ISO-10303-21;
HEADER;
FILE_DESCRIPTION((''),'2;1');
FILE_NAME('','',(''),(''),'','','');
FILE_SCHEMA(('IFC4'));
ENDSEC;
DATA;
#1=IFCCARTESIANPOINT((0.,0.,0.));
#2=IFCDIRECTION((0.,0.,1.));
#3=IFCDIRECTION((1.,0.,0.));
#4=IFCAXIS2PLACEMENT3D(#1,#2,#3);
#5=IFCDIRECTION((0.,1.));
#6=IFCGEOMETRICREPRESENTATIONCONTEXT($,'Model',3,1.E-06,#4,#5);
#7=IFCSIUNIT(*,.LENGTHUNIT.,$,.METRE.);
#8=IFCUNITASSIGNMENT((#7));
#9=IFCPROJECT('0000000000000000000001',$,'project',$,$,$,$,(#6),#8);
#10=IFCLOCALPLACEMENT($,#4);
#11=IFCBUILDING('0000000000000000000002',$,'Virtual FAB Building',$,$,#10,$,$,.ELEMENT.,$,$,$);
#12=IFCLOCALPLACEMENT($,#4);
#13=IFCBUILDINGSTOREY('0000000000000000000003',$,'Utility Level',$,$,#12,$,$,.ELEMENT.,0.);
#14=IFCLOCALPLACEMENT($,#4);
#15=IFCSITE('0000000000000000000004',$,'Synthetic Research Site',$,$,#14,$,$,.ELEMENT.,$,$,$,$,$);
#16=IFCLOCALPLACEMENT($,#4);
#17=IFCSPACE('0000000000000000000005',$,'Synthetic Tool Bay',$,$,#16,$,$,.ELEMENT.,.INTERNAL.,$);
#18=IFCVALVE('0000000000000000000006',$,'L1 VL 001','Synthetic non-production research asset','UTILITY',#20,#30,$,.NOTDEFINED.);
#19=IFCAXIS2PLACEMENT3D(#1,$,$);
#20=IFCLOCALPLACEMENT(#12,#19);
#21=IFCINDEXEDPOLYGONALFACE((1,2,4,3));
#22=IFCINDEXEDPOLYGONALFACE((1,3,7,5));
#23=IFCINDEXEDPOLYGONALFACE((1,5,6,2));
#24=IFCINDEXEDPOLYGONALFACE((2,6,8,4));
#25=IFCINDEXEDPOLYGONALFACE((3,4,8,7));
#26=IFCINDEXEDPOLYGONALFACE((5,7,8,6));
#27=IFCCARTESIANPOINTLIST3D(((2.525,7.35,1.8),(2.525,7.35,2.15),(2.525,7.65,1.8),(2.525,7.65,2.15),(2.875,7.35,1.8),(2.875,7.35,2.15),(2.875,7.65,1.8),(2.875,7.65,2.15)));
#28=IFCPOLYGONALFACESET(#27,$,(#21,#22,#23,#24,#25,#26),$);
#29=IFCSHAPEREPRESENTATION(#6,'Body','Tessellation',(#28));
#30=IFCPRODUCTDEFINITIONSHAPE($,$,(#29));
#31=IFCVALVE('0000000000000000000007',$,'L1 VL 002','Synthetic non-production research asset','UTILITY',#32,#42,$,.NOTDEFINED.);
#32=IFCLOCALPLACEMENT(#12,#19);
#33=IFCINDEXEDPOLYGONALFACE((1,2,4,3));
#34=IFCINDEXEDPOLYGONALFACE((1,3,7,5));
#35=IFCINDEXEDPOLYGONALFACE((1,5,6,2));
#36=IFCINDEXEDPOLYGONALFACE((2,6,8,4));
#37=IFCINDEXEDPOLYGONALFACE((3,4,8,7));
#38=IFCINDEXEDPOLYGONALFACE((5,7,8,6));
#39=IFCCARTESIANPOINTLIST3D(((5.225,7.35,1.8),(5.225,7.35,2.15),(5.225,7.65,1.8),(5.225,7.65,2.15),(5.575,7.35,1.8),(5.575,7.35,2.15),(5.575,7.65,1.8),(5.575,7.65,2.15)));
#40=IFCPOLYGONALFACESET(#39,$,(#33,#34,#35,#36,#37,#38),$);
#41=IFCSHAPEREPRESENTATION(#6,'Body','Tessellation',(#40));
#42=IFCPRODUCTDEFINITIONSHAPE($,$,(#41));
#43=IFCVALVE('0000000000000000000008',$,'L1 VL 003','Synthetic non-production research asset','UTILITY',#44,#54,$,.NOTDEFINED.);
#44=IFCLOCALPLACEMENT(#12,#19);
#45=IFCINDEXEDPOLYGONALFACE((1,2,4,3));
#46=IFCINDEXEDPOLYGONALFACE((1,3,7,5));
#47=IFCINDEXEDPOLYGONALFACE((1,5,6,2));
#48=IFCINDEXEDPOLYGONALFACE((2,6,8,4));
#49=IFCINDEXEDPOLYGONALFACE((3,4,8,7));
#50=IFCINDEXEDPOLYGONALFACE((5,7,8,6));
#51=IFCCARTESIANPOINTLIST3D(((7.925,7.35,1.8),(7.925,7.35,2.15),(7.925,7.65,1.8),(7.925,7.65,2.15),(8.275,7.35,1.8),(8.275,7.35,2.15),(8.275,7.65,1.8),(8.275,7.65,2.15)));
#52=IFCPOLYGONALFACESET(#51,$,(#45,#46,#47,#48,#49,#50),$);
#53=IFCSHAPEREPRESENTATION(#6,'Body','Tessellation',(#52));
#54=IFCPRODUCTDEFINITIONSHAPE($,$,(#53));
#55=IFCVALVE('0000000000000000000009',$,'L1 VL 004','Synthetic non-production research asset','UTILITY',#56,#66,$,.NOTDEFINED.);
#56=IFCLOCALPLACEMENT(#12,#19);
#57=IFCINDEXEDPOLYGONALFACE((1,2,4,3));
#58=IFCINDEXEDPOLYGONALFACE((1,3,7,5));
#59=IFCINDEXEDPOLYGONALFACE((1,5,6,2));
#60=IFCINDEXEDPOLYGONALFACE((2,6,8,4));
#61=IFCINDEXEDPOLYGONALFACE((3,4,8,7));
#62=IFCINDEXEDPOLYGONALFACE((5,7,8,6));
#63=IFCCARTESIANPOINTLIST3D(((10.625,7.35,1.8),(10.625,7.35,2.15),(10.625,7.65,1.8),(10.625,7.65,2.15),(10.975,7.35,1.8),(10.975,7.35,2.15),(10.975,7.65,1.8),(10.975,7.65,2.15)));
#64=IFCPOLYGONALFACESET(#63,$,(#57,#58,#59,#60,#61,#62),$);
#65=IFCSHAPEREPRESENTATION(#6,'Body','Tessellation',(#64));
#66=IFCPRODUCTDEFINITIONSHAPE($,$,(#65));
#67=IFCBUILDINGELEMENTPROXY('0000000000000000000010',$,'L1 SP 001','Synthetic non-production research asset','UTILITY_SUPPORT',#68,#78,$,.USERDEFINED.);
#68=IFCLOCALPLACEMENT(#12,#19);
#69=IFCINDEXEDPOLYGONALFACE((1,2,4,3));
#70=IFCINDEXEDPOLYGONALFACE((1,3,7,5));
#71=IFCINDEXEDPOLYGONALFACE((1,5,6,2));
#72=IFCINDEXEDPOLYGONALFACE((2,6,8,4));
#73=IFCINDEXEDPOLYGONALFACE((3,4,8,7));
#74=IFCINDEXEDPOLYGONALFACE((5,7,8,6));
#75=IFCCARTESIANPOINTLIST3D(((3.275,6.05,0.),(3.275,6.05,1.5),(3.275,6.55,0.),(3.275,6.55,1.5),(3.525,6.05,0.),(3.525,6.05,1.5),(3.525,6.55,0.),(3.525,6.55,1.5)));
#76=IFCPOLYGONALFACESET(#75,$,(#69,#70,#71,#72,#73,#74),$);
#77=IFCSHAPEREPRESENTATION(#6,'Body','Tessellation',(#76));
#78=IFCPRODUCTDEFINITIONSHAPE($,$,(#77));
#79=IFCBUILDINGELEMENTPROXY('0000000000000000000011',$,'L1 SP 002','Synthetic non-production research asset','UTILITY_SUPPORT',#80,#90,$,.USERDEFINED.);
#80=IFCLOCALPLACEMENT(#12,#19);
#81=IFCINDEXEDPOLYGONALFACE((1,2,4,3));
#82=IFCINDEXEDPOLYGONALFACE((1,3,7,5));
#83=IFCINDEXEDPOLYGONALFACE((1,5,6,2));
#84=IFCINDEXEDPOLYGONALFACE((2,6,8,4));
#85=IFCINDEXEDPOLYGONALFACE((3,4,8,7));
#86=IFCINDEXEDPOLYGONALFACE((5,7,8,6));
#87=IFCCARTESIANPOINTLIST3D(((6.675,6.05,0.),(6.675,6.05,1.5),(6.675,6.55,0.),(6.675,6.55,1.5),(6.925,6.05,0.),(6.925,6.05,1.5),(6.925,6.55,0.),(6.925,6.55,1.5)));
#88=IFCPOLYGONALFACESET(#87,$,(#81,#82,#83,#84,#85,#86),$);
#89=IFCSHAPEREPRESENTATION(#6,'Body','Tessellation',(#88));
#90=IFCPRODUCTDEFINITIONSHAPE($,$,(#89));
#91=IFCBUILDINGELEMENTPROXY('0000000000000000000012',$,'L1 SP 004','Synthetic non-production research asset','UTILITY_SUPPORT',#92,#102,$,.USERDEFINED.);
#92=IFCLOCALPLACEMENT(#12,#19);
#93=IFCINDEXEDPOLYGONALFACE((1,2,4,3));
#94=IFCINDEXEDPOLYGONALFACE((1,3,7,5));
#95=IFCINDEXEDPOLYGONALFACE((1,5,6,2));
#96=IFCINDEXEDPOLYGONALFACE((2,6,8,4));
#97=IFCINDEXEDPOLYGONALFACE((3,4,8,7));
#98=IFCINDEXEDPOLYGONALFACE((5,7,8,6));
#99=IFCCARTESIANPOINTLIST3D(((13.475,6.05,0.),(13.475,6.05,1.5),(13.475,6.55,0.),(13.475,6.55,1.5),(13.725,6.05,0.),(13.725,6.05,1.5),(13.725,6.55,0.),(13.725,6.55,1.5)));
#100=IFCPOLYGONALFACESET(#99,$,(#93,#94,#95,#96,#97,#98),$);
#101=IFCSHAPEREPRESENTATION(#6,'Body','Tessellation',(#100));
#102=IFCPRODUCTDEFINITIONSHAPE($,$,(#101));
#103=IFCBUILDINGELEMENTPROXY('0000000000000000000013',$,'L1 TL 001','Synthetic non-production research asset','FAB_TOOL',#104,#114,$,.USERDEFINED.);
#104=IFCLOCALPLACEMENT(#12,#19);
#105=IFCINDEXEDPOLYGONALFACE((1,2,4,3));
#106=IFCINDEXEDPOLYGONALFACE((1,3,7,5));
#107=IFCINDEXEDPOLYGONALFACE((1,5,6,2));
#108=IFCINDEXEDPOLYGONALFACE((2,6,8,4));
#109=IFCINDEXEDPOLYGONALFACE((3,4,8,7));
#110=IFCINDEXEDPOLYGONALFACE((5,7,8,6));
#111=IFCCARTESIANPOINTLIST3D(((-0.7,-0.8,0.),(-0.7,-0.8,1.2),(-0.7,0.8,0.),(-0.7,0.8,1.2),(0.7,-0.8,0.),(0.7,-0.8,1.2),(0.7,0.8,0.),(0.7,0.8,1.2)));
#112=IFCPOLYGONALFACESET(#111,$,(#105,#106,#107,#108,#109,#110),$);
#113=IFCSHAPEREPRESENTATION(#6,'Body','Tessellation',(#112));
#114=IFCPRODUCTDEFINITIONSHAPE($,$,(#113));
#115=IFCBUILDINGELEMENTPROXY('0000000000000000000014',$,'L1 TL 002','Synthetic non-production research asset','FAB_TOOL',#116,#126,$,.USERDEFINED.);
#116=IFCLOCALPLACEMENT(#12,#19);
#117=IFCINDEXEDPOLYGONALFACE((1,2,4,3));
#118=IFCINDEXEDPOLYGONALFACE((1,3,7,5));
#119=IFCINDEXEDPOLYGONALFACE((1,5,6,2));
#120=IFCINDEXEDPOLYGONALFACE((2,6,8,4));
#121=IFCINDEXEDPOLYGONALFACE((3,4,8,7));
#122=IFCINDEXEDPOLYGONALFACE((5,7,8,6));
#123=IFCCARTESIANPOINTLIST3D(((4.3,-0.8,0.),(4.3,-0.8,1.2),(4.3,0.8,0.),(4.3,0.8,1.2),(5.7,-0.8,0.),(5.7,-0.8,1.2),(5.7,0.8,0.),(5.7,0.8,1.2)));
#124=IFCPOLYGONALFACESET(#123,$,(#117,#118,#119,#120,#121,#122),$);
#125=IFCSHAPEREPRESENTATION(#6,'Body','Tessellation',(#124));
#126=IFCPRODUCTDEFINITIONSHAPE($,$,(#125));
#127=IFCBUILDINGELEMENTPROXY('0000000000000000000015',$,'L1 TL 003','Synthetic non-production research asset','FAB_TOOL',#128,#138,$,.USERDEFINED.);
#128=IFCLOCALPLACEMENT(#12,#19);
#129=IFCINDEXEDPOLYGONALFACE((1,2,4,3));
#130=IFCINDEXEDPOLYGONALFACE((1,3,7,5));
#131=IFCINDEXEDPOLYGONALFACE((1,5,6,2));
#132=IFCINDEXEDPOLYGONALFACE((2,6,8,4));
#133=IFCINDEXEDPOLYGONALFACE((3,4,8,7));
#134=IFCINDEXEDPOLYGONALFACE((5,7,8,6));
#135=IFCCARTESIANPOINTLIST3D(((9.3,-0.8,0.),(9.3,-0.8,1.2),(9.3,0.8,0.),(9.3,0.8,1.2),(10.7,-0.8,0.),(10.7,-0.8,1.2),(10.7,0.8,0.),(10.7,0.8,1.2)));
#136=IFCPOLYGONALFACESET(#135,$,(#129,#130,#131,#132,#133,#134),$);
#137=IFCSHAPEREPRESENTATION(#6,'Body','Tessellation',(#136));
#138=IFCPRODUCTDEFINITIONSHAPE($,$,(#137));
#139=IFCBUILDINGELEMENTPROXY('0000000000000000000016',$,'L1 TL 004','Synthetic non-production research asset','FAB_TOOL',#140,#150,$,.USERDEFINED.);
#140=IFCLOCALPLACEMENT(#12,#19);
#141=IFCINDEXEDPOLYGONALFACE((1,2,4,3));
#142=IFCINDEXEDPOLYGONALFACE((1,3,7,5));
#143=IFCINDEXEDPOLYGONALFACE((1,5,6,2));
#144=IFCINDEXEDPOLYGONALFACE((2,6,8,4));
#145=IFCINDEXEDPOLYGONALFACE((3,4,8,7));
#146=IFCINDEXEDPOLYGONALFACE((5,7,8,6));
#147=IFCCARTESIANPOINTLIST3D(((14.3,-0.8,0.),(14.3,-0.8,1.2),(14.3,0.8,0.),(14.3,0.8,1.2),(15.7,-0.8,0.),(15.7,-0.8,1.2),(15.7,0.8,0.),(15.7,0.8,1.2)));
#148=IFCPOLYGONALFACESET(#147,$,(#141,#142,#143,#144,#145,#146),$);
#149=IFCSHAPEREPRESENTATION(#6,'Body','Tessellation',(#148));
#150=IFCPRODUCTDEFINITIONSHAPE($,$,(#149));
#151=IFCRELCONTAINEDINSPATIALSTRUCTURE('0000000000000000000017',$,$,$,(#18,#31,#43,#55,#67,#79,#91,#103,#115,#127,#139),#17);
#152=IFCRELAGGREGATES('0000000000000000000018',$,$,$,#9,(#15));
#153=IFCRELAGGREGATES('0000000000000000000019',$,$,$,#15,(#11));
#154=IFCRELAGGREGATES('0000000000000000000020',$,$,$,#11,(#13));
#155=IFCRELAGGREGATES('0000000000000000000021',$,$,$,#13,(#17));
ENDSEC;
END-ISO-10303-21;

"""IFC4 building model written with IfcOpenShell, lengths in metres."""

from ifc_helpers import new_model, si_unit, direction, frame, origin_with_axes, origin_2d_with_axis, place, context, project, spatial, rectangle, extrude, element, save


model = new_model("IFC4")

# Units and contexts
model_context = context("Model", 3, precision=1e-06, world=origin_with_axes(), true_north=direction((0.0, 1.0)))
ifc_project = project(units=[si_unit("LENGTHUNIT", "METRE")], contexts=[model_context])

# Site, building, storey, space
site_placement = place(None, origin_with_axes())
site = spatial("IfcSite", under=ifc_project, at=site_placement, Name="Synthetic Research Site", CompositionType="ELEMENT")
building_placement = place(None, origin_with_axes())
building = spatial("IfcBuilding", under=site, at=building_placement, Name="Virtual FAB Building", CompositionType="ELEMENT")
storey_placement = place(None, origin_with_axes())
storey = spatial("IfcBuildingStorey", under=building, at=storey_placement, Name="Utility Level", CompositionType="ELEMENT", Elevation=0.0)
space_placement = place(None, origin_with_axes())
space = spatial("IfcSpace", under=storey, at=space_placement, Name="Synthetic Tool Bay", CompositionType="ELEMENT", PredefinedType="INTERNAL")

# Valves
for number, where, z_axis, x_axis, name in (
    (1, (2.7, 7.5, 1.8), (0.0, 0.0, 1.0), (1.0, 0.0, 0.0), "L1 VL 001"),
    (2, (5.4, 7.5, 1.8), (0.0, 0.0, 1.0), (1.0, 0.0, 0.0), "L1 VL 002"),
    (3, (8.1, 7.5, 1.8), (0.0, 0.0, 1.0), (1.0, 0.0, 0.0), "L1 VL 003"),
    (4, (10.8, 7.5, 1.8), (0.0, 0.0, 1.0), (1.0, 0.0, 0.0), "L1 VL 004"),
):
    element("IfcValve", number, at=place(None, frame(where, z_axis=z_axis, x_axis=x_axis)), inside=space, Name=name, Description="Synthetic non-production research asset", ObjectType="UTILITY", PredefinedType="NOTDEFINED", context=model_context, shape_type="SweptSolid", body=[
        extrude(rectangle(XDim=0.35, YDim=0.3, at=origin_2d_with_axis()), origin_with_axes(), (0.0, 0.0, 1.0), 0.35),
    ])

# Building element proxies
for number, where, z_axis, x_axis, name in (
    (5, (3.4, 6.3, 0.0), (0.0, 0.0, 1.0), (1.0, 0.0, 0.0), "L1 SP 001"),
    (6, (6.8, 6.3, 0.0), (0.0, 0.0, 1.0), (1.0, 0.0, 0.0), "L1 SP 002"),
    (7, (13.6, 6.3, 0.0), (0.0, 0.0, 1.0), (1.0, 0.0, 0.0), "L1 SP 004"),
):
    element("IfcBuildingElementProxy", number, at=place(None, frame(where, z_axis=z_axis, x_axis=x_axis)), inside=space, Name=name, Description="Synthetic non-production research asset", ObjectType="UTILITY_SUPPORT", PredefinedType="USERDEFINED", context=model_context, shape_type="SweptSolid", body=[
        extrude(rectangle(XDim=0.25, YDim=0.5, at=origin_2d_with_axis()), origin_with_axes(), (0.0, 0.0, 1.0), 1.5),
    ])
for number, where, z_axis, x_axis, name in (
    (8, (0.0, 0.0, 0.0), (0.0, 0.0, 1.0), (1.0, 0.0, 0.0), "L1 TL 001"),
    (9, (5.0, 0.0, 0.0), (0.0, 0.0, 1.0), (1.0, 0.0, 0.0), "L1 TL 002"),
    (10, (10.0, 0.0, 0.0), (0.0, 0.0, 1.0), (1.0, 0.0, 0.0), "L1 TL 003"),
    (11, (15.0, 0.0, 0.0), (0.0, 0.0, 1.0), (1.0, 0.0, 0.0), "L1 TL 004"),
):
    element("IfcBuildingElementProxy", number, at=place(None, frame(where, z_axis=z_axis, x_axis=x_axis)), inside=space, Name=name, Description="Synthetic non-production research asset", ObjectType="FAB_TOOL", PredefinedType="USERDEFINED", context=model_context, shape_type="SweptSolid", body=[
        extrude(rectangle(XDim=1.4, YDim=1.6, at=origin_2d_with_axis()), origin_with_axes(), (0.0, 0.0, 1.0), 1.2),
    ])

save(model, "model.ifc")
